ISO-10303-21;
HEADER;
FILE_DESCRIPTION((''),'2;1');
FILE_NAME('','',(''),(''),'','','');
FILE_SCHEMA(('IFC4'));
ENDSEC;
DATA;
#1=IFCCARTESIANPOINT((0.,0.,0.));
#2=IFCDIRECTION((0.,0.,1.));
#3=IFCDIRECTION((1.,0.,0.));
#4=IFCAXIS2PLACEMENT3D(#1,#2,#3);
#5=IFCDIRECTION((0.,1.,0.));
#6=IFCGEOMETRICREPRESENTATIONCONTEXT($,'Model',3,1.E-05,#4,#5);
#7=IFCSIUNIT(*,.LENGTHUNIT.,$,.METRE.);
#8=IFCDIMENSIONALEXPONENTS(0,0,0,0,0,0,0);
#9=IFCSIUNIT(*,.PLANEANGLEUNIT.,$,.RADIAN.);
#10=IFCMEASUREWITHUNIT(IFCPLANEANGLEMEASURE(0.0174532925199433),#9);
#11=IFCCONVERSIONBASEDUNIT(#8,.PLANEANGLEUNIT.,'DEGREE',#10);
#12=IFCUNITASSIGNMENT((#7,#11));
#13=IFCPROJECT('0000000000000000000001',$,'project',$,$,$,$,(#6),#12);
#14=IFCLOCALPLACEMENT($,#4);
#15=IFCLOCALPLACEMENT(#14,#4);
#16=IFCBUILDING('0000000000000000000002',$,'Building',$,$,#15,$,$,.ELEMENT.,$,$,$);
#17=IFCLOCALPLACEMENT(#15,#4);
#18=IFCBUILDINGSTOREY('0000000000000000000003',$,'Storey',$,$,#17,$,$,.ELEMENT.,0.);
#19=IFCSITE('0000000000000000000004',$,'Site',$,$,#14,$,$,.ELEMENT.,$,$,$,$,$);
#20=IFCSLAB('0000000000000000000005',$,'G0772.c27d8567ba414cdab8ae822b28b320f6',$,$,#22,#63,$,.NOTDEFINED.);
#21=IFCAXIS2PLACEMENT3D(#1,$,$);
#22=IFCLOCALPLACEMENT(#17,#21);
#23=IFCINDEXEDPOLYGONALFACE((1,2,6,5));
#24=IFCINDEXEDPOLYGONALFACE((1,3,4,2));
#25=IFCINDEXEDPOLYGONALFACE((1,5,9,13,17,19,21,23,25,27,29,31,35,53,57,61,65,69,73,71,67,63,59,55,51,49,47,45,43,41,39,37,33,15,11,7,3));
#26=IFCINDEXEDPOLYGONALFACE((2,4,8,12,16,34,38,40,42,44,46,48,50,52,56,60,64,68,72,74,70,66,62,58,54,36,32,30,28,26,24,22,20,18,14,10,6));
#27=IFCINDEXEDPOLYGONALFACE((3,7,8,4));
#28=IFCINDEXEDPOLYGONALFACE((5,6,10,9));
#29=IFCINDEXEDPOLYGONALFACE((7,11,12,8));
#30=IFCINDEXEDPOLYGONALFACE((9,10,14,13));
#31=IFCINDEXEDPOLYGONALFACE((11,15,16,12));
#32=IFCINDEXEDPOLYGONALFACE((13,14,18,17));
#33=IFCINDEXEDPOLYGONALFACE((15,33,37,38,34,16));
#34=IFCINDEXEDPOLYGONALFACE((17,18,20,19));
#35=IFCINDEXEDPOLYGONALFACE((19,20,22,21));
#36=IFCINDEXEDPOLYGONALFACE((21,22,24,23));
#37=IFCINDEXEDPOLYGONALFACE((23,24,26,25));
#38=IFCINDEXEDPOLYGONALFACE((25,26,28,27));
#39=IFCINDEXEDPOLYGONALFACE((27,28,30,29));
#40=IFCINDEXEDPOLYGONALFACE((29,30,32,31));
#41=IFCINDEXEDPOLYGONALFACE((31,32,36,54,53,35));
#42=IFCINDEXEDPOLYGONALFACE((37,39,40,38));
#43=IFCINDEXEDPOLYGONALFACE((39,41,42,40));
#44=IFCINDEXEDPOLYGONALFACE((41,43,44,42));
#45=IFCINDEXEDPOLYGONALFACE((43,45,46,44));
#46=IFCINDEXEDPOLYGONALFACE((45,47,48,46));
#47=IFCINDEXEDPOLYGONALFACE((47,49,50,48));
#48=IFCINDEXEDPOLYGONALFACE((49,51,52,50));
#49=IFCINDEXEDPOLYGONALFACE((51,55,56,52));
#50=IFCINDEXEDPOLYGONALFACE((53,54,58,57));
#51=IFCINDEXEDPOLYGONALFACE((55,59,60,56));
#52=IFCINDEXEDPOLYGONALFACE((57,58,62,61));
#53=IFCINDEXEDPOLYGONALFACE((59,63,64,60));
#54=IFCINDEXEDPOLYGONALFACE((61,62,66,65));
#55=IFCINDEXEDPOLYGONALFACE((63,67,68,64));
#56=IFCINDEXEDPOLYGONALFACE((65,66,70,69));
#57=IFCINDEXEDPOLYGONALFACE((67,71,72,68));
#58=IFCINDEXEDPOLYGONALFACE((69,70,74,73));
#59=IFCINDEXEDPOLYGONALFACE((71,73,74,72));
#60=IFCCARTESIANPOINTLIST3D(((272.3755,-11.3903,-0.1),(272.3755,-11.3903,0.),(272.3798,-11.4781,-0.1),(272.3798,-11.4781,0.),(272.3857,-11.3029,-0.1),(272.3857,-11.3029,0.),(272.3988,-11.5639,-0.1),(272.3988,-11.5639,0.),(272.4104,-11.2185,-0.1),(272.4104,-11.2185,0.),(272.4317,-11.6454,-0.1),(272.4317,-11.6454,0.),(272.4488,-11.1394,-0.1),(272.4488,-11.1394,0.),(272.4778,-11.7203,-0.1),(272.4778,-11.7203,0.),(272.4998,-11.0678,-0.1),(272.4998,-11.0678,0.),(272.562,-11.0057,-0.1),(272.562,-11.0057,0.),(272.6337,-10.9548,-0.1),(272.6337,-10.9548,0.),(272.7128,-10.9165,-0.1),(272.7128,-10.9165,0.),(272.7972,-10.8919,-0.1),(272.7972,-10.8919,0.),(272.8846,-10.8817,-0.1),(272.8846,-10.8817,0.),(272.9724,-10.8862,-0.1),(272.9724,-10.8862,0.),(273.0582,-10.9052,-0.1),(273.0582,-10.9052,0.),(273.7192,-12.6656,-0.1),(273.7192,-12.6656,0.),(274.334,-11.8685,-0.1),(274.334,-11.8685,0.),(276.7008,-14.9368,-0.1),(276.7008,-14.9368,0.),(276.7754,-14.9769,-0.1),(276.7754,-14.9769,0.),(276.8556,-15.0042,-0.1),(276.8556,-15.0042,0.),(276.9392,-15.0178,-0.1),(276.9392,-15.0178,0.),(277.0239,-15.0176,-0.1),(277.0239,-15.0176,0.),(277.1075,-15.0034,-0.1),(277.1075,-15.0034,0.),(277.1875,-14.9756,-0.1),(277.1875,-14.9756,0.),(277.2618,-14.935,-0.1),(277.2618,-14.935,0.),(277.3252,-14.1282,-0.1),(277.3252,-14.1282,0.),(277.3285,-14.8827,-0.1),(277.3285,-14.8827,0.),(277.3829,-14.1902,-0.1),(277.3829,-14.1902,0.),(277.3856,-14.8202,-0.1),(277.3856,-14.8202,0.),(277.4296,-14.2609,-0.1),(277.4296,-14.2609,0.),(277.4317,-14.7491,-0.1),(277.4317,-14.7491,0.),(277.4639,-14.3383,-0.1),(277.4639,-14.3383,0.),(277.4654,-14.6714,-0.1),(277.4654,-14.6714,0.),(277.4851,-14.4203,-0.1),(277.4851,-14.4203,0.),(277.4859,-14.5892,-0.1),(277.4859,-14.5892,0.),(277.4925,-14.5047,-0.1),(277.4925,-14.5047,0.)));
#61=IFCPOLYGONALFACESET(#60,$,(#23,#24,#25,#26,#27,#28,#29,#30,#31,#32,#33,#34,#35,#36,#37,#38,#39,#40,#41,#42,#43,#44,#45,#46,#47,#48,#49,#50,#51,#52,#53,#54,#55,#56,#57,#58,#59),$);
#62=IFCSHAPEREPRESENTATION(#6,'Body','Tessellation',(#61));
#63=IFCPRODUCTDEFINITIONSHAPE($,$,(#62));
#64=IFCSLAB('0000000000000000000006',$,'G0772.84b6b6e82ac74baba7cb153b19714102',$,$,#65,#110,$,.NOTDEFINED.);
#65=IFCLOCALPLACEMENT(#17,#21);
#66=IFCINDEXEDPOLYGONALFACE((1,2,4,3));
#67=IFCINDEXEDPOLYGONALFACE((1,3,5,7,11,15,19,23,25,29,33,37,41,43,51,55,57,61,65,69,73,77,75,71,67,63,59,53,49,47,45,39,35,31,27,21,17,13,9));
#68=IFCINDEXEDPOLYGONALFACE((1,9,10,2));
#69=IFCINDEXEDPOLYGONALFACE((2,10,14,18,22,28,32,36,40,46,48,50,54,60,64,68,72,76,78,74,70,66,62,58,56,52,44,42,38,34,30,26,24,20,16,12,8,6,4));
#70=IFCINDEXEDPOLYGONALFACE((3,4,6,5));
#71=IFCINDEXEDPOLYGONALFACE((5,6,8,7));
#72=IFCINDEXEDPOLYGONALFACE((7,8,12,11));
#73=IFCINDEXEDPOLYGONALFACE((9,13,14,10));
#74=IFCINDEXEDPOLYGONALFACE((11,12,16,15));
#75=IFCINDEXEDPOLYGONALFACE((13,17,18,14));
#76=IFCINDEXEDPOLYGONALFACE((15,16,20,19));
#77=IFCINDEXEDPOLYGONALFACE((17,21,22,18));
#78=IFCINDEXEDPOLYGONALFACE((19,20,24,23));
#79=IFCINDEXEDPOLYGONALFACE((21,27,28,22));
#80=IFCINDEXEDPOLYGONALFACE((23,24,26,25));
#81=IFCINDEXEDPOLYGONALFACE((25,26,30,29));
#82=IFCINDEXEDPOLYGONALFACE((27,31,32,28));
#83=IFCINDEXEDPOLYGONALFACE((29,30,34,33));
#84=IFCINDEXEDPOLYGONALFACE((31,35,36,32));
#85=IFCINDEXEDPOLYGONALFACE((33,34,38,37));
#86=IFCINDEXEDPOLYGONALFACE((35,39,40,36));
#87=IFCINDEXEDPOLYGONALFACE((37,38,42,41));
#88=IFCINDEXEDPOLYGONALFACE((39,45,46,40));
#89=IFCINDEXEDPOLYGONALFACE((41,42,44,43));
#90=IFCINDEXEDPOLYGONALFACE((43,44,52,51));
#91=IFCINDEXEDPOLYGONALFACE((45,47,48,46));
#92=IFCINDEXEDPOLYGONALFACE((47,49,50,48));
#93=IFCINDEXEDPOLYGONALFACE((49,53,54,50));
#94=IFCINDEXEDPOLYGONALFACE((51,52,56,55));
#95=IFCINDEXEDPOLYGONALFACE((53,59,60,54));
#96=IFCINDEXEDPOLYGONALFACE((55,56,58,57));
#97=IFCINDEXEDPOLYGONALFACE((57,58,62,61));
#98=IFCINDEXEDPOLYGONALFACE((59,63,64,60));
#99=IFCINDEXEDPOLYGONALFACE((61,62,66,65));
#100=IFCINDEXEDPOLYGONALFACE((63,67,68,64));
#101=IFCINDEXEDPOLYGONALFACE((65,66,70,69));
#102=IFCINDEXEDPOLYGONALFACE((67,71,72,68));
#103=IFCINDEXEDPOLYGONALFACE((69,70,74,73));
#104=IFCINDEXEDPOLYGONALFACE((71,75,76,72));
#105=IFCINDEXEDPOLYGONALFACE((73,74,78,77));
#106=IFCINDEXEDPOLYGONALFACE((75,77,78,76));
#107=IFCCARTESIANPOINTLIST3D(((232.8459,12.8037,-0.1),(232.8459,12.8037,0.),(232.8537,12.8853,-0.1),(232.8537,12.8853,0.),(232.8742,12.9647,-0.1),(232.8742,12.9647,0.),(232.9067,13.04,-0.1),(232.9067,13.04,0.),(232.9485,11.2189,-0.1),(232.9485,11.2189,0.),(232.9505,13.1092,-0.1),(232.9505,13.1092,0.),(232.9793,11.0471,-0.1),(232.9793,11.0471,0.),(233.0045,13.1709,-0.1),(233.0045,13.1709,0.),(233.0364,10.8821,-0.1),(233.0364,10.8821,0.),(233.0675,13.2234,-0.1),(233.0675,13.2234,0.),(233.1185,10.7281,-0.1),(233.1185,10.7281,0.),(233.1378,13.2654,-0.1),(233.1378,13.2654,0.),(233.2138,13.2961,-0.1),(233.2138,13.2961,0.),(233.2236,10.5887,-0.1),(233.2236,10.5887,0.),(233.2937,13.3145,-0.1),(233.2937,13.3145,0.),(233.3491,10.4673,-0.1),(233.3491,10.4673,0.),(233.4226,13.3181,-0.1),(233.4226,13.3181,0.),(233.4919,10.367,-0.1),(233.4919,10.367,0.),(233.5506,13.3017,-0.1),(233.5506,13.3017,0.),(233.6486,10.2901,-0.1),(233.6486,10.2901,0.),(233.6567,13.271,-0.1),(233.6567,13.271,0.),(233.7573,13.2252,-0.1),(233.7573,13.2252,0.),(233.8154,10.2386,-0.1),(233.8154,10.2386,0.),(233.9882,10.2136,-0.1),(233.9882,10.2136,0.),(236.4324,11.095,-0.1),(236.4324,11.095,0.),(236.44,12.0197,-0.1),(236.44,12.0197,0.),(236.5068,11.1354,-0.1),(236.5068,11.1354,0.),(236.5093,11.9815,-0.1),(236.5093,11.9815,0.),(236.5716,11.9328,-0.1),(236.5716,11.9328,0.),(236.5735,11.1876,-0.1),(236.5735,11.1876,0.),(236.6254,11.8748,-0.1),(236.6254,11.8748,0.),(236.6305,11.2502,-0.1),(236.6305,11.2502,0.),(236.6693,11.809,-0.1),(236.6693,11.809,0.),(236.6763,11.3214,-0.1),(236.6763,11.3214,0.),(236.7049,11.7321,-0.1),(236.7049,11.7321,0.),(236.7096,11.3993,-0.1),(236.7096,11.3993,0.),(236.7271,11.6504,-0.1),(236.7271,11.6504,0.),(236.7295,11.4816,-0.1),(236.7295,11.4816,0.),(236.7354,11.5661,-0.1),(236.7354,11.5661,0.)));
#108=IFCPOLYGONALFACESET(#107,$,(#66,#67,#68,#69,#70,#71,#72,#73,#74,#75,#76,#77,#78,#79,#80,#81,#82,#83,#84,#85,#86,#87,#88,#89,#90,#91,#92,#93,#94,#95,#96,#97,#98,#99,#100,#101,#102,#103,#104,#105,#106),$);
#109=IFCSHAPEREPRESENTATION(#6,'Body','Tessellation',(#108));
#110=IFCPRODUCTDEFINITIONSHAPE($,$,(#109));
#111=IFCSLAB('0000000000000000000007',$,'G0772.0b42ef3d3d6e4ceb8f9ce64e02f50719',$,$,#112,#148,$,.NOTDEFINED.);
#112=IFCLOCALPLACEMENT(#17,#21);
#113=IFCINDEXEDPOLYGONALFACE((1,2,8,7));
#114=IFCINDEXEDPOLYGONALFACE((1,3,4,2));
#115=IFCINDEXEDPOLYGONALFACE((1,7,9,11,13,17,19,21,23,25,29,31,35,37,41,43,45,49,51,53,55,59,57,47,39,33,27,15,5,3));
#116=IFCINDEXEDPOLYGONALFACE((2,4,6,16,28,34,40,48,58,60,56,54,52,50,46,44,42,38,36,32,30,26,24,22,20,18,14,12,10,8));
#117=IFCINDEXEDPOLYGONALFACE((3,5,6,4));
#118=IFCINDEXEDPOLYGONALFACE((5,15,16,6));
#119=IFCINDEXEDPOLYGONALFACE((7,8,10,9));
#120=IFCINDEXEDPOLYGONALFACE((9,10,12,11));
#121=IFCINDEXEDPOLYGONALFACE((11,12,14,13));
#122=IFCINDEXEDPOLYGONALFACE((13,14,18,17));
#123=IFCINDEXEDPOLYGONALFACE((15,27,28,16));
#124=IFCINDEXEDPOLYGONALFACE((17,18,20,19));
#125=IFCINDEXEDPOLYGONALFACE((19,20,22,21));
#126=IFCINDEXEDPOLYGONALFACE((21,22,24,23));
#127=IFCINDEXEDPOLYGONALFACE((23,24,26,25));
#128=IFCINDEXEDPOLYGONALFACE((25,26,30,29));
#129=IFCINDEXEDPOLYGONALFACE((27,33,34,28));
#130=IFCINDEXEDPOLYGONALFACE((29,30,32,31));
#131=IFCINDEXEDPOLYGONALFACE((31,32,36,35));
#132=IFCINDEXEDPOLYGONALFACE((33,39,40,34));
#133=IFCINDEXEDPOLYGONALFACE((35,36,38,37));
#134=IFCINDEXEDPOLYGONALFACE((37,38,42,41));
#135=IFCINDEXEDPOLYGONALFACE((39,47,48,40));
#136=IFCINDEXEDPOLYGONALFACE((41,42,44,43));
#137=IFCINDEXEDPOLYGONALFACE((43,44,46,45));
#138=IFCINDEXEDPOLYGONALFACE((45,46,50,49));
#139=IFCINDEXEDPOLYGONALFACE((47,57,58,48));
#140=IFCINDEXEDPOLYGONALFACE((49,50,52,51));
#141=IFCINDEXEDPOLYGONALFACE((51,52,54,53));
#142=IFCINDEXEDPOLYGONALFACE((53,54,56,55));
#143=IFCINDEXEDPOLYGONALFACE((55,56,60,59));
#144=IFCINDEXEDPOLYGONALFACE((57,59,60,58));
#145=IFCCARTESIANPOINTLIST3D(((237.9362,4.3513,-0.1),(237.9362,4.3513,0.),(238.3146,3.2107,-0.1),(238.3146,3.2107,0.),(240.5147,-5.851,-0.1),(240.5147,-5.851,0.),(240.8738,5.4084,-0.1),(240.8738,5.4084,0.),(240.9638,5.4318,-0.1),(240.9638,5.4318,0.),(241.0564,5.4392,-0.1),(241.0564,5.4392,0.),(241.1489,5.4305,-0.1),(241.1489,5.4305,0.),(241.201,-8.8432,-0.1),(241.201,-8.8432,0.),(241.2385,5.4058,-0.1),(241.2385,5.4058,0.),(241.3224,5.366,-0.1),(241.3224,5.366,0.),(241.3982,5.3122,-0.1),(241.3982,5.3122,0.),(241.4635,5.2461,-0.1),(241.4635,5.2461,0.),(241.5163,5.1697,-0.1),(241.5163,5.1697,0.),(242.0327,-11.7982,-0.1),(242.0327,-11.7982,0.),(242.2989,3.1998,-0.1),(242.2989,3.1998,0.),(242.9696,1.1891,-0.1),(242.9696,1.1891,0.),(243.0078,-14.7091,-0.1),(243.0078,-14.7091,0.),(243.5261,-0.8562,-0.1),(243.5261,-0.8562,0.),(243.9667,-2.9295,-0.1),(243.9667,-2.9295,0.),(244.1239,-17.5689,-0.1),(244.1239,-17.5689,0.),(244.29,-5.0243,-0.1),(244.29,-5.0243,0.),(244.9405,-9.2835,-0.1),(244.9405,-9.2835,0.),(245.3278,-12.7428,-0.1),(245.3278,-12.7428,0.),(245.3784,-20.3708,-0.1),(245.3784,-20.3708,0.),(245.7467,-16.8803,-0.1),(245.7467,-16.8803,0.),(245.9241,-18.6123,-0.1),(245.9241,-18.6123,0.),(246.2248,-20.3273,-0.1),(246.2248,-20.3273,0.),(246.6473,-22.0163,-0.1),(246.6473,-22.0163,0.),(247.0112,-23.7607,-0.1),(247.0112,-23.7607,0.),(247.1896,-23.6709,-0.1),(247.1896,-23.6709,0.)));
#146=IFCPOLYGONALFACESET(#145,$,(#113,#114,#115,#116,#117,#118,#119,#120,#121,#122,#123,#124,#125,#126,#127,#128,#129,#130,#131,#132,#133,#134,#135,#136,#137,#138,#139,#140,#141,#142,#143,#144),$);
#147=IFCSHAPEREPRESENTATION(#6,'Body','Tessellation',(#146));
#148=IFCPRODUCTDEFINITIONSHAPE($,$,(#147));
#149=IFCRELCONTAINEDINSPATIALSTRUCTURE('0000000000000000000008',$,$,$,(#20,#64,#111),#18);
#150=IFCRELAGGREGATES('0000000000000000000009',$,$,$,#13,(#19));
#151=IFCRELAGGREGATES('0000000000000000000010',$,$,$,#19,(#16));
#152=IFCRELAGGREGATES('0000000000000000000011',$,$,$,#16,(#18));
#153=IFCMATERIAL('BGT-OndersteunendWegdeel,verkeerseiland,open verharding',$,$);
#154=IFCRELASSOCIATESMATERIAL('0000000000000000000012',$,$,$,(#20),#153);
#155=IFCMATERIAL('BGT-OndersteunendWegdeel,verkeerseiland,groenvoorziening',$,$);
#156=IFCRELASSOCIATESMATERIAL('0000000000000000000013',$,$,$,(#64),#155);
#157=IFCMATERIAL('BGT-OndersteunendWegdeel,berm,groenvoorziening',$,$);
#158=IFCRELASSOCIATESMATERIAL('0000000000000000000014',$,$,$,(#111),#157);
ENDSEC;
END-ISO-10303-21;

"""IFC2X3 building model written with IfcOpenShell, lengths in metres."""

from ifc_helpers import new_model, entity, si_unit, converted_unit, direction, frame, origin_with_axes, place, context, project, spatial, polyline, outline, extrude, material, element, save


model = new_model("IFC2X3")

# Units and contexts
model_context = context("Model", 3, precision=1e-05, world=origin_with_axes(), true_north=direction((0.0, 1.0, 0.0)))
ifc_project = project(units=[si_unit("LENGTHUNIT", "METRE"), converted_unit("PLANEANGLEUNIT", "DEGREE", entity("IfcPlaneAngleMeasure", 0.0174532925199433), si_unit("PLANEANGLEUNIT", "RADIAN"), dimensions=[0, 0, 0, 0, 0, 0, 0])], contexts=[model_context])

# Site, building, storey
site_placement = place(None, origin_with_axes())
site = spatial("IfcSite", under=ifc_project, at=site_placement, Name="Site", CompositionType="ELEMENT")
building_placement = place(site_placement, origin_with_axes())
building = spatial("IfcBuilding", under=site, at=building_placement, Name="Building", CompositionType="ELEMENT")
storey_placement = place(building_placement, origin_with_axes())
storey = spatial("IfcBuildingStorey", under=building, at=storey_placement, Name="Storey", CompositionType="ELEMENT", Elevation=0.0)

# Slabs
ifc_material_1 = material(Name="BGT-OndersteunendWegdeel,berm,groenvoorziening")
ifc_material_2 = material(Name="BGT-OndersteunendWegdeel,verkeerseiland,open verharding")
slab_1_placement = place(storey_placement, frame((0.0, 0.0, -0.1), z_axis=(0.0, 0.0, 1.0), x_axis=(1.0, 0.0, 0.0)))
element("IfcSlab", 1, at=slab_1_placement, inside=storey, material=ifc_material_2, Name="G0772.c27d8567ba414cdab8ae822b28b320f6", PredefinedType="NOTDEFINED", context=model_context, shape_type="SweptSolid", body=[
    extrude(outline(polyline([(277.3252, -14.1282), (277.3829, -14.1902), (277.4296, -14.2609), (277.4639, -14.3383), (277.4851, -14.4203), (277.4925, -14.5047), (277.4859, -14.5892), (277.4654, -14.6714), (277.4317, -14.7491), (277.3856, -14.8202), (277.3285, -14.8827), (277.2618, -14.935), (277.1875, -14.9756), (277.1075, -15.0034), (277.0239, -15.0176), (276.9392, -15.0178), (276.8556, -15.0042), (276.7754, -14.9769), (276.7008, -14.9368), (273.7192, -12.6656), (272.4778, -11.7203), (272.4317, -11.6454), (272.3988, -11.5639), (272.3798, -11.4781), (272.3755, -11.3903), (272.3857, -11.3029), (272.4104, -11.2185), (272.4488, -11.1394), (272.4998, -11.0678), (272.562, -11.0057), (272.6337, -10.9548), (272.7128, -10.9165), (272.7972, -10.8919), (272.8846, -10.8817), (272.9724, -10.8862), (273.0582, -10.9052), (274.334, -11.8685), (277.3252, -14.1282)])), origin_with_axes(), (0.0, 0.0, 1.0), 0.1),
])
ifc_material_3 = material(Name="BGT-OndersteunendWegdeel,verkeerseiland,groenvoorziening")
slab_2_placement = place(storey_placement, frame((0.0, 0.0, -0.1), z_axis=(0.0, 0.0, 1.0), x_axis=(1.0, 0.0, 0.0)))
element("IfcSlab", 2, at=slab_2_placement, inside=storey, material=ifc_material_3, Name="G0772.84b6b6e82ac74baba7cb153b19714102", PredefinedType="NOTDEFINED", context=model_context, shape_type="SweptSolid", body=[
    extrude(outline(polyline([(233.6567, 13.271), (233.7573, 13.2252), (236.44, 12.0197), (236.5093, 11.9815), (236.5716, 11.9328), (236.6254, 11.8748), (236.6693, 11.809), (236.7049, 11.7321), (236.7271, 11.6504), (236.7354, 11.5661), (236.7295, 11.4816), (236.7096, 11.3993), (236.6763, 11.3214), (236.6305, 11.2502), (236.5735, 11.1876), (236.5068, 11.1354), (236.4324, 11.095), (233.9882, 10.2136), (233.8154, 10.2386), (233.6486, 10.2901), (233.4919, 10.367), (233.3491, 10.4673), (233.2236, 10.5887), (233.1185, 10.7281), (233.0364, 10.8821), (232.9793, 11.0471), (232.9485, 11.2189), (232.8459, 12.8037), (232.8537, 12.8853), (232.8742, 12.9647), (232.9067, 13.04), (232.9505, 13.1092), (233.0045, 13.1709), (233.0675, 13.2234), (233.1378, 13.2654), (233.2138, 13.2961), (233.2937, 13.3145), (233.4226, 13.3181), (233.5506, 13.3017), (233.6567, 13.271)])), origin_with_axes(), (0.0, 0.0, 1.0), 0.1),
])
slab_3_placement = place(storey_placement, frame((0.0, 0.0, -0.1), z_axis=(0.0, 0.0, 1.0), x_axis=(1.0, 0.0, 0.0)))
element("IfcSlab", 3, at=slab_3_placement, inside=storey, material=ifc_material_1, Name="G0772.0b42ef3d3d6e4ceb8f9ce64e02f50719", PredefinedType="NOTDEFINED", context=model_context, shape_type="SweptSolid", body=[
    extrude(outline(polyline([(242.2989, 3.1998), (242.9696, 1.1891), (243.5261, -0.8562), (243.9667, -2.9295), (244.29, -5.0243), (244.9405, -9.2835), (245.3278, -12.7428), (245.7467, -16.8803), (245.9241, -18.6123), (246.2248, -20.3273), (246.6473, -22.0163), (247.1896, -23.6709), (247.0112, -23.7607), (245.3784, -20.3708), (244.1239, -17.5689), (243.0078, -14.7091), (242.0327, -11.7982), (241.201, -8.8432), (240.5147, -5.851), (238.3146, 3.2107), (237.9362, 4.3513), (240.8738, 5.4084), (240.9638, 5.4318), (241.0564, 5.4392), (241.1489, 5.4305), (241.2385, 5.4058), (241.3224, 5.366), (241.3982, 5.3122), (241.4635, 5.2461), (241.5163, 5.1697), (242.2989, 3.1998)])), origin_with_axes(), (0.0, 0.0, 1.0), 0.1),
])

save(model, "model.ifc")
